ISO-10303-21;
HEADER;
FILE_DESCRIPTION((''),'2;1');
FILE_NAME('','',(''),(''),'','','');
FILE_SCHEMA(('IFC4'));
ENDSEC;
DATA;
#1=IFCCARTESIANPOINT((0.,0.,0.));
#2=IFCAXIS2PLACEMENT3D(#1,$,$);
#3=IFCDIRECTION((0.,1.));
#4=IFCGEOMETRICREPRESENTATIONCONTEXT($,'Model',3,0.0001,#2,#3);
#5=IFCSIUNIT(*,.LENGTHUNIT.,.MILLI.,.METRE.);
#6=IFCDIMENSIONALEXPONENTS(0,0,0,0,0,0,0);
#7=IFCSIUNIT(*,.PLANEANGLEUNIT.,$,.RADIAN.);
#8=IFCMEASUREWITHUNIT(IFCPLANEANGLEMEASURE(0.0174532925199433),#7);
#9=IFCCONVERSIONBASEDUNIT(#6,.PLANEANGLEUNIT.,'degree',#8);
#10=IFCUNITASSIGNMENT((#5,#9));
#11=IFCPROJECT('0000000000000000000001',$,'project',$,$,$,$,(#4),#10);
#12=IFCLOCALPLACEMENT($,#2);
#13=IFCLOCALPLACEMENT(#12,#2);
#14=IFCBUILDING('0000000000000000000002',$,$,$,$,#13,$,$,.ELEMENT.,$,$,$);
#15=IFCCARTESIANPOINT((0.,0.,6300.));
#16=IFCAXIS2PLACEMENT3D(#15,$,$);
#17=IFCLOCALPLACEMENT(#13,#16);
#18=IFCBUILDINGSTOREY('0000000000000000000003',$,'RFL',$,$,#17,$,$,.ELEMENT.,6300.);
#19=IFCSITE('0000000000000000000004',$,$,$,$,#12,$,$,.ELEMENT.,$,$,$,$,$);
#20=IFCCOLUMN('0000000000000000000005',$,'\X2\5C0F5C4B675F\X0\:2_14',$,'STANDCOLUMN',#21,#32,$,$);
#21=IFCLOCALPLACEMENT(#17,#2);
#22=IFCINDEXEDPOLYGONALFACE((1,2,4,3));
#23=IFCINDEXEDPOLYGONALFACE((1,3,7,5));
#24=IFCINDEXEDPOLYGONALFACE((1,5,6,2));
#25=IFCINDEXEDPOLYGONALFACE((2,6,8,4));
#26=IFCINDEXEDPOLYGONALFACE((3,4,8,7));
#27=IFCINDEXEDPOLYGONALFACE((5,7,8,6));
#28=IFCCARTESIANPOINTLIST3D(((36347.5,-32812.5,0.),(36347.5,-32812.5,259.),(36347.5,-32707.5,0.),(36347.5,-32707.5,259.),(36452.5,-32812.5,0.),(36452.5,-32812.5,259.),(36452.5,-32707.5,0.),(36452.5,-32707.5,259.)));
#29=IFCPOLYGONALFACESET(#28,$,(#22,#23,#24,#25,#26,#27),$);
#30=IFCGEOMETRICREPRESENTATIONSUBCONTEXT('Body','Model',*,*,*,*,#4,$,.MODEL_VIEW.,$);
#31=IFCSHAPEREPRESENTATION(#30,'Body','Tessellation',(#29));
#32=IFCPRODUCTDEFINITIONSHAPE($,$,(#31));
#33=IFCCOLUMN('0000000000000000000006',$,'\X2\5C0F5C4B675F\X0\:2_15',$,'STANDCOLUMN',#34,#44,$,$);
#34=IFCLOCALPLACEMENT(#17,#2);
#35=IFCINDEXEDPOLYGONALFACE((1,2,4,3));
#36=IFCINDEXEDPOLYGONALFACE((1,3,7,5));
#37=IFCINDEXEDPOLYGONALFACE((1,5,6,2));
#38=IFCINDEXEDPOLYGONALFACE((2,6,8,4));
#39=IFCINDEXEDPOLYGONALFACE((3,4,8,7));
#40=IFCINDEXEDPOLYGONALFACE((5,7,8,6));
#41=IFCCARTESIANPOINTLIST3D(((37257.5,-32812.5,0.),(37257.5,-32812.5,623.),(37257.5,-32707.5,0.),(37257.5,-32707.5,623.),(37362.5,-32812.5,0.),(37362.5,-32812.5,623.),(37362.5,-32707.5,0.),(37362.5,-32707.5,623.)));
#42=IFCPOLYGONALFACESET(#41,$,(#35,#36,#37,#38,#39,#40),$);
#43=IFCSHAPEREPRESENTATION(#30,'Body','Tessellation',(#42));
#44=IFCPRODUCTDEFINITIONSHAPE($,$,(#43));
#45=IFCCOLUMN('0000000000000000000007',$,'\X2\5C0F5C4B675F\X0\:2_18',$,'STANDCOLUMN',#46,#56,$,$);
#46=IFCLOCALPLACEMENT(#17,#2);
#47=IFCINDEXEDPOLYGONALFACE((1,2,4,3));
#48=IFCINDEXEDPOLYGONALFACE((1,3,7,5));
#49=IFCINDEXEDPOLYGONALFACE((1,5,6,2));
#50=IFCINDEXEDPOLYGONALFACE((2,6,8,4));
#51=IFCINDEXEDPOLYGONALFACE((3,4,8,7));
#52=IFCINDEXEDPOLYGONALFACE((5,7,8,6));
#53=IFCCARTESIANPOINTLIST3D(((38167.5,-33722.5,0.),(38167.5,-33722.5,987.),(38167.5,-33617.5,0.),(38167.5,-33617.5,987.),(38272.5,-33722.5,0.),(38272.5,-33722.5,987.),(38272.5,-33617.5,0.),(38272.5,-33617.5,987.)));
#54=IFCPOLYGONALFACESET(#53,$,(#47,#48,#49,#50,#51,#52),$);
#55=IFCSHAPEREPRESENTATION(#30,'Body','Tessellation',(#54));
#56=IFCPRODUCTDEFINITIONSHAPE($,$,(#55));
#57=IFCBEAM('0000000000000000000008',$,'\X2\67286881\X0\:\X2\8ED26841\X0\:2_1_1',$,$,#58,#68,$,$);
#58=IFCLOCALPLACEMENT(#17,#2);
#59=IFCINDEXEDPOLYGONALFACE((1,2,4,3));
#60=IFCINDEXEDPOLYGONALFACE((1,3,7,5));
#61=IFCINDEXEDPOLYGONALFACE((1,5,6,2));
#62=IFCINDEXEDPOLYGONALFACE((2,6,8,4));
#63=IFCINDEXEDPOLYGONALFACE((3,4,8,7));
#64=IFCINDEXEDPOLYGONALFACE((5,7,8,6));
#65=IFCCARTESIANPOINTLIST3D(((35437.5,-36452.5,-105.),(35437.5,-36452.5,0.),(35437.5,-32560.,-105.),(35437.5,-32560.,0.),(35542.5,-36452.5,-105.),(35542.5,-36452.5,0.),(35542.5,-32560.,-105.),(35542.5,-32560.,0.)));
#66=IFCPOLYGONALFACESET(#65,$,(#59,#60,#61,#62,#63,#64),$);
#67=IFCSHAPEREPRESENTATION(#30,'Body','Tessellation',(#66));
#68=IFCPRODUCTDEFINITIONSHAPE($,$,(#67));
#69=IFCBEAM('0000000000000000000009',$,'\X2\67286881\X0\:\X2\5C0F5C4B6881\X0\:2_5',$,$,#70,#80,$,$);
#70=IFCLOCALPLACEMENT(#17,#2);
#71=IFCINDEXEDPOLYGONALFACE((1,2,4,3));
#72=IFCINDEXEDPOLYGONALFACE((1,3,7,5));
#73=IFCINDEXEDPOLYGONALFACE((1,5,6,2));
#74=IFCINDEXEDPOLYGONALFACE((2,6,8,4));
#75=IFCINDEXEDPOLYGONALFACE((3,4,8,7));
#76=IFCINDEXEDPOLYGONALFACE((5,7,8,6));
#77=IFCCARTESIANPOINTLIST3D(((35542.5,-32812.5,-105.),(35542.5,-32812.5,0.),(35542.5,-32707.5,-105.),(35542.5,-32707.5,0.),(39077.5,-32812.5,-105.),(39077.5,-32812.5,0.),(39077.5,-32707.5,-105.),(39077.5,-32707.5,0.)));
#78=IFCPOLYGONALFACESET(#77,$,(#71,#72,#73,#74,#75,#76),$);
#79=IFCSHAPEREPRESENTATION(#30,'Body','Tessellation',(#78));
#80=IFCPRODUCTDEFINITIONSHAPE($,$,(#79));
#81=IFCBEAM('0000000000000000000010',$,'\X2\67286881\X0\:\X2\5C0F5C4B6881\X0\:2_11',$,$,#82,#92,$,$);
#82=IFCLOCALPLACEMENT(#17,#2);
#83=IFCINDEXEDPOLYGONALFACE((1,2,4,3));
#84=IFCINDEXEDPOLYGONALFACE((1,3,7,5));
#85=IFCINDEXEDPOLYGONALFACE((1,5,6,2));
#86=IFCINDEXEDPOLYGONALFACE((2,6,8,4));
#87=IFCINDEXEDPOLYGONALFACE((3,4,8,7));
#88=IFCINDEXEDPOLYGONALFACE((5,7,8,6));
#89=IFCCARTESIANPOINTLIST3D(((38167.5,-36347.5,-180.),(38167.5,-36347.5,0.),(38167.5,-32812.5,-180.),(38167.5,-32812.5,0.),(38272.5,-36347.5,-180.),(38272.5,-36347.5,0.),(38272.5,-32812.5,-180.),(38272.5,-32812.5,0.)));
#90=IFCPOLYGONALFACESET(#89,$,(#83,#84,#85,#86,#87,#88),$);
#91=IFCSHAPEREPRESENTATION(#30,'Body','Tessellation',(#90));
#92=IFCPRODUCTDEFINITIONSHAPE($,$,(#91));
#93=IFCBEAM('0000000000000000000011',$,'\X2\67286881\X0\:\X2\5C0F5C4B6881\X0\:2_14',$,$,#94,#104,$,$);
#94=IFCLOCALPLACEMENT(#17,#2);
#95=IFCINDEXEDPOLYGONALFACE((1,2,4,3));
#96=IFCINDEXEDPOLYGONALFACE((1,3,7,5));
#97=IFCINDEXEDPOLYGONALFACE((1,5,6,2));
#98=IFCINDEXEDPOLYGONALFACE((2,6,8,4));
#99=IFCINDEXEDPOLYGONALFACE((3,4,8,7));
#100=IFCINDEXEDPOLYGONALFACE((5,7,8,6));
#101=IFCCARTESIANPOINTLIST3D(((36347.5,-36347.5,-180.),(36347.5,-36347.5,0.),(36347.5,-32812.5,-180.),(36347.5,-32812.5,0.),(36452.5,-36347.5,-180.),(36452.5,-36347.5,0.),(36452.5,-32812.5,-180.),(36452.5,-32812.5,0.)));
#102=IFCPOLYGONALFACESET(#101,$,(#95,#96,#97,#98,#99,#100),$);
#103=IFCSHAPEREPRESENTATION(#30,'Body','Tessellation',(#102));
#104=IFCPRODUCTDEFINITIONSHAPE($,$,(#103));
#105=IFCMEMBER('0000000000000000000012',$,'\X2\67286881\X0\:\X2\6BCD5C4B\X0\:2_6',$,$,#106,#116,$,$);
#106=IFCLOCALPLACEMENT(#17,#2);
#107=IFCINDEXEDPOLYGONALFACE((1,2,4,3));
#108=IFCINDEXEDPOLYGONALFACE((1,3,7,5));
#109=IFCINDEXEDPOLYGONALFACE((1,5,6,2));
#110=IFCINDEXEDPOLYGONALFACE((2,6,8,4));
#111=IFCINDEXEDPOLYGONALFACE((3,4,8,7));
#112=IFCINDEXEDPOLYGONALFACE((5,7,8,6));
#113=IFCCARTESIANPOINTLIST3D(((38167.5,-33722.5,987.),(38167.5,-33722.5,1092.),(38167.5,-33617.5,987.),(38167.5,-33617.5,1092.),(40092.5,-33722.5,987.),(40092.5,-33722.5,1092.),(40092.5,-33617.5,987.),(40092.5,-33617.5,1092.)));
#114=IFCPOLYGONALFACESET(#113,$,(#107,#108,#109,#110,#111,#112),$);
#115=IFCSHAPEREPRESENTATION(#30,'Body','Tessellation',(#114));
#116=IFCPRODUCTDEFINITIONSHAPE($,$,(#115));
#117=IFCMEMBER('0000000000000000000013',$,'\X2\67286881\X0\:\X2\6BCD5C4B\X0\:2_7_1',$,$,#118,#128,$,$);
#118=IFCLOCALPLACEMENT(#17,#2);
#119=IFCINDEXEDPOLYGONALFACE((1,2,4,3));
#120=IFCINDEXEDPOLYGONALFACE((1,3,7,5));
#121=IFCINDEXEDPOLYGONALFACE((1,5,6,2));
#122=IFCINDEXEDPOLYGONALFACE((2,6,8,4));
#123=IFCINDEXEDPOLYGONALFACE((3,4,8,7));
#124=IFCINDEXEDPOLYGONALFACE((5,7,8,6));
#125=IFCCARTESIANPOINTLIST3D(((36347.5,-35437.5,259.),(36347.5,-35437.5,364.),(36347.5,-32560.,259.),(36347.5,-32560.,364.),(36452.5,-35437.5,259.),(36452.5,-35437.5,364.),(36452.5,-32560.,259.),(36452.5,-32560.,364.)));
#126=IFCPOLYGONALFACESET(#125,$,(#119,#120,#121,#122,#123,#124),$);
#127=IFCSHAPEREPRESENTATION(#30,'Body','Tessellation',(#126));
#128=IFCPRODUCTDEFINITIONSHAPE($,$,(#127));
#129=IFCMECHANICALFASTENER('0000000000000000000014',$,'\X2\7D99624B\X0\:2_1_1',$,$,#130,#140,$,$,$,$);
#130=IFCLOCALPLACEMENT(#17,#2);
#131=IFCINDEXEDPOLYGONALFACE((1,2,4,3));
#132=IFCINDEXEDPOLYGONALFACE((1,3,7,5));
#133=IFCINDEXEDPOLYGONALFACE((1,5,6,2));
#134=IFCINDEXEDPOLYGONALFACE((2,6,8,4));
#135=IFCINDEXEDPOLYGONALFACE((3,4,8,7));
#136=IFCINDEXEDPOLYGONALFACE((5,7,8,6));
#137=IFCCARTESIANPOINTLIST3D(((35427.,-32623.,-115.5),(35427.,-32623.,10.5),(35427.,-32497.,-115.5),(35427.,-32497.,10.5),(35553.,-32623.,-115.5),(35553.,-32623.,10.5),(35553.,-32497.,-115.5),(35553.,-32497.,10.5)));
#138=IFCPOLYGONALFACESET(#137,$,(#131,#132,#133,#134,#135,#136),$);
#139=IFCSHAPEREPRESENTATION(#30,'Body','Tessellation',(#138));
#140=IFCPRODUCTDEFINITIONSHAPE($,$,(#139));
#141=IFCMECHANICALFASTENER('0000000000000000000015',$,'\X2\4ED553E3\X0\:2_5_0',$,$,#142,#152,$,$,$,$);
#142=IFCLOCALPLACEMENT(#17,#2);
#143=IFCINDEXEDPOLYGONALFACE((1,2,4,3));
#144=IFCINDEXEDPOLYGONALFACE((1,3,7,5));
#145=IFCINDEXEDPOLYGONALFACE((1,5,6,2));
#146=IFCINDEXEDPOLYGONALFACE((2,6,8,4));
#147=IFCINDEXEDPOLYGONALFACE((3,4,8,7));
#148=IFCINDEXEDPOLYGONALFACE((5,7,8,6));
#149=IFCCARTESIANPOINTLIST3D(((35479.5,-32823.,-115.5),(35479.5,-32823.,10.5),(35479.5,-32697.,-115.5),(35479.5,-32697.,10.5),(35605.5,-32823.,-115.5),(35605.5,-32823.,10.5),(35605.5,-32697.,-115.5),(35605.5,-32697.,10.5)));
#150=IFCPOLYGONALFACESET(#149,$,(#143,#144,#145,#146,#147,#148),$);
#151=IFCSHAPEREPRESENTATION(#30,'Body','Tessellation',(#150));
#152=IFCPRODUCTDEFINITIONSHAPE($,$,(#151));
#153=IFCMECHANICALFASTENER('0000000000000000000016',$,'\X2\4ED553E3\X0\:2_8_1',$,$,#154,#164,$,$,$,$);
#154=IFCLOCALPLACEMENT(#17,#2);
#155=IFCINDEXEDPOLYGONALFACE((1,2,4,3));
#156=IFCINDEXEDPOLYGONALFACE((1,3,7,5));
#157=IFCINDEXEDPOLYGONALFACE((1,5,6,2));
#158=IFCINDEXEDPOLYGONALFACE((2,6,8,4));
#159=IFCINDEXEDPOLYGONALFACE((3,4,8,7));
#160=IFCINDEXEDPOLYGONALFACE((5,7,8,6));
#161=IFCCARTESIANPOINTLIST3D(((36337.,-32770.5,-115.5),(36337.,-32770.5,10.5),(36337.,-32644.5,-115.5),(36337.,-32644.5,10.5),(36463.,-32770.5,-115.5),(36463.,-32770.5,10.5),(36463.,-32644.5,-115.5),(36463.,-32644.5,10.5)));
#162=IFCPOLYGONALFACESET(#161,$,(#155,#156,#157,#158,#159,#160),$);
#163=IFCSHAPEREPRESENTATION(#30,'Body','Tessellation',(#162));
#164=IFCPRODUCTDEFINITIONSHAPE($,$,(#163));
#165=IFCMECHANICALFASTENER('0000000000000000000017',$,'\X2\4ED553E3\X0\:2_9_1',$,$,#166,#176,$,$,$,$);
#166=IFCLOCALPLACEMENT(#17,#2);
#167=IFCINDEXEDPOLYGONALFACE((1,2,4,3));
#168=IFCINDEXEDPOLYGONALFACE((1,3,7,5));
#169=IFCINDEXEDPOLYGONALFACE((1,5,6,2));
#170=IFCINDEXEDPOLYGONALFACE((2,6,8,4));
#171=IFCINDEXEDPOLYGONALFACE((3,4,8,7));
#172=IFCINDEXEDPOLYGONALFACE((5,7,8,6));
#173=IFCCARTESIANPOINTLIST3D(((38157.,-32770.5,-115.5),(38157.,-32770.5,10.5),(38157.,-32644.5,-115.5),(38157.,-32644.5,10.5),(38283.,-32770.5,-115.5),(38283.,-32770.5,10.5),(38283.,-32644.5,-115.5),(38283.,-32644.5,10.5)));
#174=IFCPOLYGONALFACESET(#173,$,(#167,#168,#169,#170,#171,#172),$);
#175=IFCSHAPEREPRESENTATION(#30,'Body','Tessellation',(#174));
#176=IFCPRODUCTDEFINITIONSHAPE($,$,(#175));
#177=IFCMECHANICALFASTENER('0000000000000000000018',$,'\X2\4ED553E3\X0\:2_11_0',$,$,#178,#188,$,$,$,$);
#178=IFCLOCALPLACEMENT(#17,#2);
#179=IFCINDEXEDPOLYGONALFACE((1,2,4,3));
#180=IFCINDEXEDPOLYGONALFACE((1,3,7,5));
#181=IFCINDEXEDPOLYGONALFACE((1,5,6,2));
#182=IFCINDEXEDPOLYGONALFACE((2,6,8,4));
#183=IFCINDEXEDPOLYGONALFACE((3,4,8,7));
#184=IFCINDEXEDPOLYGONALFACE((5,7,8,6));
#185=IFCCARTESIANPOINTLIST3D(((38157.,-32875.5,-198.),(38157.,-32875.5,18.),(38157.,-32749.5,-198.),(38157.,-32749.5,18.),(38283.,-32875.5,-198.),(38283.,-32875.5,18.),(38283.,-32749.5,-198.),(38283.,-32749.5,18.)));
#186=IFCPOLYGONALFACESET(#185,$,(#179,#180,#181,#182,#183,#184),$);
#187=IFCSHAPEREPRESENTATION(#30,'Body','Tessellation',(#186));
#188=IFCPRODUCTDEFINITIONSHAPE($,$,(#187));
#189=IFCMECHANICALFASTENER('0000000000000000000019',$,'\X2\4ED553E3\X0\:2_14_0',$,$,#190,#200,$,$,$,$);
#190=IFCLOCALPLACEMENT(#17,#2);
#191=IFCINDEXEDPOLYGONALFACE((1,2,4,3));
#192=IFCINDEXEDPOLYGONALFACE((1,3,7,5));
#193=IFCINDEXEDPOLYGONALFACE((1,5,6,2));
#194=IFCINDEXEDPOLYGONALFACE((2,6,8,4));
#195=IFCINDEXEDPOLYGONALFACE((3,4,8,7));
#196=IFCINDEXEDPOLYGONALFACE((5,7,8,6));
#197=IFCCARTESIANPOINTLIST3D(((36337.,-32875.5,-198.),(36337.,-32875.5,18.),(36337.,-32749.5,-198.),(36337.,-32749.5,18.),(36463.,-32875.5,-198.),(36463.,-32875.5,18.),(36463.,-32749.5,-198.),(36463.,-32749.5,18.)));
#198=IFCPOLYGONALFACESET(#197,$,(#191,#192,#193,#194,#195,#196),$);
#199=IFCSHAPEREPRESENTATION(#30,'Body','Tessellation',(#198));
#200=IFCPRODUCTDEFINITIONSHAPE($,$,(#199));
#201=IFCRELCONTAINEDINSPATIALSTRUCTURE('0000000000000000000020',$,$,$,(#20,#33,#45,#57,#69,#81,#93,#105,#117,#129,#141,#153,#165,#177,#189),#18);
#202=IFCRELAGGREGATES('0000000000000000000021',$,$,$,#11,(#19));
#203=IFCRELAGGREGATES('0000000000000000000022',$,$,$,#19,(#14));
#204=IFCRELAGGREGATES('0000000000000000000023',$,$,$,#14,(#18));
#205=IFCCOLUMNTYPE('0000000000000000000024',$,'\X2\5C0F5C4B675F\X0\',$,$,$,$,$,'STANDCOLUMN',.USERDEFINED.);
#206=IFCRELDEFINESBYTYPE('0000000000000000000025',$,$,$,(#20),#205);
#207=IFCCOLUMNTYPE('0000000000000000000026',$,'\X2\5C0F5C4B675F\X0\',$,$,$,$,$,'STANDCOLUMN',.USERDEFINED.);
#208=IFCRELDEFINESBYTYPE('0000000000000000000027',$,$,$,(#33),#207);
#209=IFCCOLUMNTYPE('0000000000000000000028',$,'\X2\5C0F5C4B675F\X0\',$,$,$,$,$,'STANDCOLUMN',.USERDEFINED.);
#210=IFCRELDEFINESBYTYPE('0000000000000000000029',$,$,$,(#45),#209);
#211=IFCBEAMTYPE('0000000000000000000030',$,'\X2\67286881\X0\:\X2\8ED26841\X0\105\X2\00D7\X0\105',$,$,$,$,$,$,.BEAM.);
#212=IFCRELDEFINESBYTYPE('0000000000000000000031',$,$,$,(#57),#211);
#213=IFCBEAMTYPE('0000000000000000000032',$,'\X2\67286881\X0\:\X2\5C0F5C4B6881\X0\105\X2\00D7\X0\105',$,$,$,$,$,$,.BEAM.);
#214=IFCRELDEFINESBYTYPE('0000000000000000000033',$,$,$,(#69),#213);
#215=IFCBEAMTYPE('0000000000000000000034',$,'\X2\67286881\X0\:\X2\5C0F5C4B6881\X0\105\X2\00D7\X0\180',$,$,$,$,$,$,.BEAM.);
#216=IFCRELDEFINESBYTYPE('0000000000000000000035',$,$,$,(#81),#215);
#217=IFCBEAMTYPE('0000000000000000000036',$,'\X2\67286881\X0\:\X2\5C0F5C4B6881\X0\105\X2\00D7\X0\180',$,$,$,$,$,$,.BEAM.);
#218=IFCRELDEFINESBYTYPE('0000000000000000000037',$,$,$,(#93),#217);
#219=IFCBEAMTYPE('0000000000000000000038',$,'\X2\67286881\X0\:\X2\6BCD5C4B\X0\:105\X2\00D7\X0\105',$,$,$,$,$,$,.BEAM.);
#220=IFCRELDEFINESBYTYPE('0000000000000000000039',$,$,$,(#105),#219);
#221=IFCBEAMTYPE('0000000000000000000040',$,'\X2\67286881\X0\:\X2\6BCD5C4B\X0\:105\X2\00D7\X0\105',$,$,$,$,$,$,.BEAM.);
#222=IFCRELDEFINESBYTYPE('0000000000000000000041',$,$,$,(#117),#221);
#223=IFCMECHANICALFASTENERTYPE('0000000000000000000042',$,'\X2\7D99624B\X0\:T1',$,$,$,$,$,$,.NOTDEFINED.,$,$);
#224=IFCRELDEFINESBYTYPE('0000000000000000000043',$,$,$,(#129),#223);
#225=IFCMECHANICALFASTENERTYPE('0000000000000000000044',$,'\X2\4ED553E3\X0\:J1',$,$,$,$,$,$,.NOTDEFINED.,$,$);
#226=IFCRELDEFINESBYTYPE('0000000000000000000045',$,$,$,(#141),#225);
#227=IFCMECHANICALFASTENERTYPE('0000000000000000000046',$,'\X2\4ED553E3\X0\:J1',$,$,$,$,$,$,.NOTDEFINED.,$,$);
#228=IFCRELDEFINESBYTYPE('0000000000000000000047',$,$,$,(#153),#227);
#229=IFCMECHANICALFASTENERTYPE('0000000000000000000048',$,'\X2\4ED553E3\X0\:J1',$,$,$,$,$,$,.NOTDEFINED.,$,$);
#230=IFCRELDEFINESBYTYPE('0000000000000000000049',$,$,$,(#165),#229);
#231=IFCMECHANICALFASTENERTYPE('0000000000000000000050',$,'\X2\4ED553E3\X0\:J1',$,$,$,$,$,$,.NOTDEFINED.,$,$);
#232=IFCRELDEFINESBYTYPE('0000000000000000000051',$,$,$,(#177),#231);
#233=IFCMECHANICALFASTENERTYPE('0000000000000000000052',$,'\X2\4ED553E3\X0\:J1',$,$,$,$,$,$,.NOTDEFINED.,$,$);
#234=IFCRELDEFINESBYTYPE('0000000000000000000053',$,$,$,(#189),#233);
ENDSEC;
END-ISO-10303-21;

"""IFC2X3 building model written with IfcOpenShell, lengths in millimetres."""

from ifc_helpers import new_model, entity, si_unit, converted_unit, direction, frame, origin, origin_with_axes, origin_2d, place, context, subcontext, project, spatial, rectangle, extrude, type_object, element, save


model = new_model("IFC2X3")

# Units and contexts
model_context = context("Model", 3, precision=0.0001, world=origin(), true_north=direction((0.0, 1.0)))
body_context = subcontext(model_context, "Body", "Model", "MODEL_VIEW")
ifc_project = project(units=[si_unit("LENGTHUNIT", "METRE", prefix="MILLI"), converted_unit("PLANEANGLEUNIT", "degree", entity("IfcPlaneAngleMeasure", 0.0174532925199433), si_unit("PLANEANGLEUNIT", "RADIAN"), dimensions=[0, 0, 0, 0, 0, 0, 0])], contexts=[model_context])

# Site, building, storey
site_placement = place(None, origin())
site = spatial("IfcSite", under=ifc_project, at=site_placement, CompositionType="ELEMENT")
building_placement = place(site_placement, origin())
building = spatial("IfcBuilding", under=site, at=building_placement, CompositionType="ELEMENT")
storey_placement = place(building_placement, frame((0.0, 0.0, 6300.0)))
storey = spatial("IfcBuildingStorey", under=building, at=storey_placement, Name="RFL", CompositionType="ELEMENT", Elevation=6300.0)

# Columns
column_type_1 = type_object("IfcColumnType", Name="小屋束", ElementType="STANDCOLUMN", PredefinedType="USERDEFINED")
column_1_placement = place(storey_placement, frame((36400.0, -32760.0, 0.0)))
element("IfcColumn", 1, at=column_1_placement, inside=storey, type_object=column_type_1, Name="小屋束:2_14", ObjectType="STANDCOLUMN", context=body_context, shape_type="SweptSolid", body=[
    extrude(rectangle(XDim=105.0, YDim=105.0, at=origin_2d()), origin_with_axes(), (0.0, 0.0, 1.0), 259.0),
])
column_type_2 = type_object("IfcColumnType", Name="小屋束", ElementType="STANDCOLUMN", PredefinedType="USERDEFINED")
column_2_placement = place(storey_placement, frame((37310.0, -32760.0, 0.0)))
element("IfcColumn", 2, at=column_2_placement, inside=storey, type_object=column_type_2, Name="小屋束:2_15", ObjectType="STANDCOLUMN", context=body_context, shape_type="SweptSolid", body=[
    extrude(rectangle(XDim=105.0, YDim=105.0, at=origin_2d()), origin_with_axes(), (0.0, 0.0, 1.0), 623.0),
])
column_type_3 = type_object("IfcColumnType", Name="小屋束", ElementType="STANDCOLUMN", PredefinedType="USERDEFINED")
column_3_placement = place(storey_placement, frame((38220.0, -33670.0, 0.0)))
element("IfcColumn", 3, at=column_3_placement, inside=storey, type_object=column_type_3, Name="小屋束:2_18", ObjectType="STANDCOLUMN", context=body_context, shape_type="SweptSolid", body=[
    extrude(rectangle(XDim=105.0, YDim=105.0, at=origin_2d()), origin_with_axes(), (0.0, 0.0, 1.0), 987.0),
])

# Beams
beam_type_1 = type_object("IfcBeamType", Name="木梁:軒桁105×105", PredefinedType="BEAM")
beam_1_placement = place(storey_placement, frame((35490.0, -32560.0, -52.5), z_axis=(0.0, -1.0, 0.0), x_axis=(1.0, 0.0, 0.0)))
element("IfcBeam", 4, at=beam_1_placement, inside=storey, type_object=beam_type_1, Name="木梁:軒桁:2_1_1", context=body_context, shape_type="SweptSolid", body=[
    extrude(rectangle(XDim=105.0, YDim=105.0, at=origin_2d()), origin_with_axes(), (0.0, 0.0, 1.0), 3892.5),
])
beam_type_2 = type_object("IfcBeamType", Name="木梁:小屋梁105×105", PredefinedType="BEAM")
beam_2_placement = place(storey_placement, frame((35542.5, -32760.0, -52.5), z_axis=(1.0, 0.0, 0.0), x_axis=(0.0, 1.0, 0.0)))
element("IfcBeam", 5, at=beam_2_placement, inside=storey, type_object=beam_type_2, Name="木梁:小屋梁:2_5", context=body_context, shape_type="SweptSolid", body=[
    extrude(rectangle(XDim=105.0, YDim=105.0, at=origin_2d()), origin_with_axes(), (0.0, 0.0, 1.0), 3535.0),
])
beam_type_3 = type_object("IfcBeamType", Name="木梁:小屋梁105×180", PredefinedType="BEAM")
beam_3_placement = place(storey_placement, frame((38220.0, -32812.5, -90.0), z_axis=(0.0, -1.0, 0.0), x_axis=(1.0, 0.0, 0.0)))
element("IfcBeam", 6, at=beam_3_placement, inside=storey, type_object=beam_type_3, Name="木梁:小屋梁:2_11", context=body_context, shape_type="SweptSolid", body=[
    extrude(rectangle(XDim=105.0, YDim=180.0, at=origin_2d()), origin_with_axes(), (0.0, 0.0, 1.0), 3535.0),
])
beam_type_4 = type_object("IfcBeamType", Name="木梁:小屋梁105×180", PredefinedType="BEAM")
beam_4_placement = place(storey_placement, frame((36400.0, -32812.5, -90.0), z_axis=(0.0, -1.0, 0.0), x_axis=(1.0, 0.0, 0.0)))
element("IfcBeam", 7, at=beam_4_placement, inside=storey, type_object=beam_type_4, Name="木梁:小屋梁:2_14", context=body_context, shape_type="SweptSolid", body=[
    extrude(rectangle(XDim=105.0, YDim=180.0, at=origin_2d()), origin_with_axes(), (0.0, 0.0, 1.0), 3535.0),
])

# Members
beam_type_5 = type_object("IfcBeamType", Name="木梁:母屋:105×105", PredefinedType="BEAM")
member_1_placement = place(storey_placement, frame((38167.5, -33670.0, 1039.5), z_axis=(1.0, 0.0, 0.0), x_axis=(0.0, -1.0, 0.0)))
element("IfcMember", 8, at=member_1_placement, inside=storey, type_object=beam_type_5, Name="木梁:母屋:2_6", context=body_context, shape_type="SweptSolid", body=[
    extrude(rectangle(XDim=105.0, YDim=105.0, at=origin_2d()), origin_with_axes(), (0.0, 0.0, 1.0), 1925.0),
])
beam_type_6 = type_object("IfcBeamType", Name="木梁:母屋:105×105", PredefinedType="BEAM")
member_2_placement = place(storey_placement, frame((36400.0, -32560.0, 311.5), z_axis=(0.0, -1.0, 0.0), x_axis=(-1.0, 0.0, 0.0)))
element("IfcMember", 9, at=member_2_placement, inside=storey, type_object=beam_type_6, Name="木梁:母屋:2_7_1", context=body_context, shape_type="SweptSolid", body=[
    extrude(rectangle(XDim=105.0, YDim=105.0, at=origin_2d()), origin_with_axes(), (0.0, 0.0, 1.0), 2877.5),
])

# Mechanical fasteners
mechanical_fastener_type_1 = type_object("IfcMechanicalFastenerType", Name="継手:T1")
mechanical_fastener_1_placement = place(storey_placement, frame((35490.0, -32560.0, -115.5)))
element("IfcMechanicalFastener", 10, at=mechanical_fastener_1_placement, inside=storey, type_object=mechanical_fastener_type_1, Name="継手:2_1_1", context=body_context, shape_type="SweptSolid", body=[
    extrude(rectangle(XDim=126.0, YDim=126.0, at=origin_2d()), origin_with_axes(), (0.0, 0.0, 1.0), 126.0),
])
mechanical_fastener_type_2 = type_object("IfcMechanicalFastenerType", Name="仕口:J1")
mechanical_fastener_2_placement = place(storey_placement, frame((35542.5, -32760.0, -115.5)))
element("IfcMechanicalFastener", 11, at=mechanical_fastener_2_placement, inside=storey, type_object=mechanical_fastener_type_2, Name="仕口:2_5_0", context=body_context, shape_type="SweptSolid", body=[
    extrude(rectangle(XDim=126.0, YDim=126.0, at=origin_2d()), origin_with_axes(), (0.0, 0.0, 1.0), 126.0),
])
mechanical_fastener_type_3 = type_object("IfcMechanicalFastenerType", Name="仕口:J1")
mechanical_fastener_3_placement = place(storey_placement, frame((36400.0, -32707.5, -115.5)))
element("IfcMechanicalFastener", 12, at=mechanical_fastener_3_placement, inside=storey, type_object=mechanical_fastener_type_3, Name="仕口:2_8_1", context=body_context, shape_type="SweptSolid", body=[
    extrude(rectangle(XDim=126.0, YDim=126.0, at=origin_2d()), origin_with_axes(), (0.0, 0.0, 1.0), 126.0),
])
mechanical_fastener_type_4 = type_object("IfcMechanicalFastenerType", Name="仕口:J1")
mechanical_fastener_4_placement = place(storey_placement, frame((38220.0, -32707.5, -115.5)))
element("IfcMechanicalFastener", 13, at=mechanical_fastener_4_placement, inside=storey, type_object=mechanical_fastener_type_4, Name="仕口:2_9_1", context=body_context, shape_type="SweptSolid", body=[
    extrude(rectangle(XDim=126.0, YDim=126.0, at=origin_2d()), origin_with_axes(), (0.0, 0.0, 1.0), 126.0),
])
mechanical_fastener_type_5 = type_object("IfcMechanicalFastenerType", Name="仕口:J1")
mechanical_fastener_5_placement = place(storey_placement, frame((38220.0, -32812.5, -198.0)))
element("IfcMechanicalFastener", 14, at=mechanical_fastener_5_placement, inside=storey, type_object=mechanical_fastener_type_5, Name="仕口:2_11_0", context=body_context, shape_type="SweptSolid", body=[
    extrude(rectangle(XDim=126.0, YDim=126.0, at=origin_2d()), origin_with_axes(), (0.0, 0.0, 1.0), 216.0),
])
mechanical_fastener_type_6 = type_object("IfcMechanicalFastenerType", Name="仕口:J1")
mechanical_fastener_6_placement = place(storey_placement, frame((36400.0, -32812.5, -198.0)))
element("IfcMechanicalFastener", 15, at=mechanical_fastener_6_placement, inside=storey, type_object=mechanical_fastener_type_6, Name="仕口:2_14_0", context=body_context, shape_type="SweptSolid", body=[
    extrude(rectangle(XDim=126.0, YDim=126.0, at=origin_2d()), origin_with_axes(), (0.0, 0.0, 1.0), 216.0),
])

save(model, "model.ifc")
